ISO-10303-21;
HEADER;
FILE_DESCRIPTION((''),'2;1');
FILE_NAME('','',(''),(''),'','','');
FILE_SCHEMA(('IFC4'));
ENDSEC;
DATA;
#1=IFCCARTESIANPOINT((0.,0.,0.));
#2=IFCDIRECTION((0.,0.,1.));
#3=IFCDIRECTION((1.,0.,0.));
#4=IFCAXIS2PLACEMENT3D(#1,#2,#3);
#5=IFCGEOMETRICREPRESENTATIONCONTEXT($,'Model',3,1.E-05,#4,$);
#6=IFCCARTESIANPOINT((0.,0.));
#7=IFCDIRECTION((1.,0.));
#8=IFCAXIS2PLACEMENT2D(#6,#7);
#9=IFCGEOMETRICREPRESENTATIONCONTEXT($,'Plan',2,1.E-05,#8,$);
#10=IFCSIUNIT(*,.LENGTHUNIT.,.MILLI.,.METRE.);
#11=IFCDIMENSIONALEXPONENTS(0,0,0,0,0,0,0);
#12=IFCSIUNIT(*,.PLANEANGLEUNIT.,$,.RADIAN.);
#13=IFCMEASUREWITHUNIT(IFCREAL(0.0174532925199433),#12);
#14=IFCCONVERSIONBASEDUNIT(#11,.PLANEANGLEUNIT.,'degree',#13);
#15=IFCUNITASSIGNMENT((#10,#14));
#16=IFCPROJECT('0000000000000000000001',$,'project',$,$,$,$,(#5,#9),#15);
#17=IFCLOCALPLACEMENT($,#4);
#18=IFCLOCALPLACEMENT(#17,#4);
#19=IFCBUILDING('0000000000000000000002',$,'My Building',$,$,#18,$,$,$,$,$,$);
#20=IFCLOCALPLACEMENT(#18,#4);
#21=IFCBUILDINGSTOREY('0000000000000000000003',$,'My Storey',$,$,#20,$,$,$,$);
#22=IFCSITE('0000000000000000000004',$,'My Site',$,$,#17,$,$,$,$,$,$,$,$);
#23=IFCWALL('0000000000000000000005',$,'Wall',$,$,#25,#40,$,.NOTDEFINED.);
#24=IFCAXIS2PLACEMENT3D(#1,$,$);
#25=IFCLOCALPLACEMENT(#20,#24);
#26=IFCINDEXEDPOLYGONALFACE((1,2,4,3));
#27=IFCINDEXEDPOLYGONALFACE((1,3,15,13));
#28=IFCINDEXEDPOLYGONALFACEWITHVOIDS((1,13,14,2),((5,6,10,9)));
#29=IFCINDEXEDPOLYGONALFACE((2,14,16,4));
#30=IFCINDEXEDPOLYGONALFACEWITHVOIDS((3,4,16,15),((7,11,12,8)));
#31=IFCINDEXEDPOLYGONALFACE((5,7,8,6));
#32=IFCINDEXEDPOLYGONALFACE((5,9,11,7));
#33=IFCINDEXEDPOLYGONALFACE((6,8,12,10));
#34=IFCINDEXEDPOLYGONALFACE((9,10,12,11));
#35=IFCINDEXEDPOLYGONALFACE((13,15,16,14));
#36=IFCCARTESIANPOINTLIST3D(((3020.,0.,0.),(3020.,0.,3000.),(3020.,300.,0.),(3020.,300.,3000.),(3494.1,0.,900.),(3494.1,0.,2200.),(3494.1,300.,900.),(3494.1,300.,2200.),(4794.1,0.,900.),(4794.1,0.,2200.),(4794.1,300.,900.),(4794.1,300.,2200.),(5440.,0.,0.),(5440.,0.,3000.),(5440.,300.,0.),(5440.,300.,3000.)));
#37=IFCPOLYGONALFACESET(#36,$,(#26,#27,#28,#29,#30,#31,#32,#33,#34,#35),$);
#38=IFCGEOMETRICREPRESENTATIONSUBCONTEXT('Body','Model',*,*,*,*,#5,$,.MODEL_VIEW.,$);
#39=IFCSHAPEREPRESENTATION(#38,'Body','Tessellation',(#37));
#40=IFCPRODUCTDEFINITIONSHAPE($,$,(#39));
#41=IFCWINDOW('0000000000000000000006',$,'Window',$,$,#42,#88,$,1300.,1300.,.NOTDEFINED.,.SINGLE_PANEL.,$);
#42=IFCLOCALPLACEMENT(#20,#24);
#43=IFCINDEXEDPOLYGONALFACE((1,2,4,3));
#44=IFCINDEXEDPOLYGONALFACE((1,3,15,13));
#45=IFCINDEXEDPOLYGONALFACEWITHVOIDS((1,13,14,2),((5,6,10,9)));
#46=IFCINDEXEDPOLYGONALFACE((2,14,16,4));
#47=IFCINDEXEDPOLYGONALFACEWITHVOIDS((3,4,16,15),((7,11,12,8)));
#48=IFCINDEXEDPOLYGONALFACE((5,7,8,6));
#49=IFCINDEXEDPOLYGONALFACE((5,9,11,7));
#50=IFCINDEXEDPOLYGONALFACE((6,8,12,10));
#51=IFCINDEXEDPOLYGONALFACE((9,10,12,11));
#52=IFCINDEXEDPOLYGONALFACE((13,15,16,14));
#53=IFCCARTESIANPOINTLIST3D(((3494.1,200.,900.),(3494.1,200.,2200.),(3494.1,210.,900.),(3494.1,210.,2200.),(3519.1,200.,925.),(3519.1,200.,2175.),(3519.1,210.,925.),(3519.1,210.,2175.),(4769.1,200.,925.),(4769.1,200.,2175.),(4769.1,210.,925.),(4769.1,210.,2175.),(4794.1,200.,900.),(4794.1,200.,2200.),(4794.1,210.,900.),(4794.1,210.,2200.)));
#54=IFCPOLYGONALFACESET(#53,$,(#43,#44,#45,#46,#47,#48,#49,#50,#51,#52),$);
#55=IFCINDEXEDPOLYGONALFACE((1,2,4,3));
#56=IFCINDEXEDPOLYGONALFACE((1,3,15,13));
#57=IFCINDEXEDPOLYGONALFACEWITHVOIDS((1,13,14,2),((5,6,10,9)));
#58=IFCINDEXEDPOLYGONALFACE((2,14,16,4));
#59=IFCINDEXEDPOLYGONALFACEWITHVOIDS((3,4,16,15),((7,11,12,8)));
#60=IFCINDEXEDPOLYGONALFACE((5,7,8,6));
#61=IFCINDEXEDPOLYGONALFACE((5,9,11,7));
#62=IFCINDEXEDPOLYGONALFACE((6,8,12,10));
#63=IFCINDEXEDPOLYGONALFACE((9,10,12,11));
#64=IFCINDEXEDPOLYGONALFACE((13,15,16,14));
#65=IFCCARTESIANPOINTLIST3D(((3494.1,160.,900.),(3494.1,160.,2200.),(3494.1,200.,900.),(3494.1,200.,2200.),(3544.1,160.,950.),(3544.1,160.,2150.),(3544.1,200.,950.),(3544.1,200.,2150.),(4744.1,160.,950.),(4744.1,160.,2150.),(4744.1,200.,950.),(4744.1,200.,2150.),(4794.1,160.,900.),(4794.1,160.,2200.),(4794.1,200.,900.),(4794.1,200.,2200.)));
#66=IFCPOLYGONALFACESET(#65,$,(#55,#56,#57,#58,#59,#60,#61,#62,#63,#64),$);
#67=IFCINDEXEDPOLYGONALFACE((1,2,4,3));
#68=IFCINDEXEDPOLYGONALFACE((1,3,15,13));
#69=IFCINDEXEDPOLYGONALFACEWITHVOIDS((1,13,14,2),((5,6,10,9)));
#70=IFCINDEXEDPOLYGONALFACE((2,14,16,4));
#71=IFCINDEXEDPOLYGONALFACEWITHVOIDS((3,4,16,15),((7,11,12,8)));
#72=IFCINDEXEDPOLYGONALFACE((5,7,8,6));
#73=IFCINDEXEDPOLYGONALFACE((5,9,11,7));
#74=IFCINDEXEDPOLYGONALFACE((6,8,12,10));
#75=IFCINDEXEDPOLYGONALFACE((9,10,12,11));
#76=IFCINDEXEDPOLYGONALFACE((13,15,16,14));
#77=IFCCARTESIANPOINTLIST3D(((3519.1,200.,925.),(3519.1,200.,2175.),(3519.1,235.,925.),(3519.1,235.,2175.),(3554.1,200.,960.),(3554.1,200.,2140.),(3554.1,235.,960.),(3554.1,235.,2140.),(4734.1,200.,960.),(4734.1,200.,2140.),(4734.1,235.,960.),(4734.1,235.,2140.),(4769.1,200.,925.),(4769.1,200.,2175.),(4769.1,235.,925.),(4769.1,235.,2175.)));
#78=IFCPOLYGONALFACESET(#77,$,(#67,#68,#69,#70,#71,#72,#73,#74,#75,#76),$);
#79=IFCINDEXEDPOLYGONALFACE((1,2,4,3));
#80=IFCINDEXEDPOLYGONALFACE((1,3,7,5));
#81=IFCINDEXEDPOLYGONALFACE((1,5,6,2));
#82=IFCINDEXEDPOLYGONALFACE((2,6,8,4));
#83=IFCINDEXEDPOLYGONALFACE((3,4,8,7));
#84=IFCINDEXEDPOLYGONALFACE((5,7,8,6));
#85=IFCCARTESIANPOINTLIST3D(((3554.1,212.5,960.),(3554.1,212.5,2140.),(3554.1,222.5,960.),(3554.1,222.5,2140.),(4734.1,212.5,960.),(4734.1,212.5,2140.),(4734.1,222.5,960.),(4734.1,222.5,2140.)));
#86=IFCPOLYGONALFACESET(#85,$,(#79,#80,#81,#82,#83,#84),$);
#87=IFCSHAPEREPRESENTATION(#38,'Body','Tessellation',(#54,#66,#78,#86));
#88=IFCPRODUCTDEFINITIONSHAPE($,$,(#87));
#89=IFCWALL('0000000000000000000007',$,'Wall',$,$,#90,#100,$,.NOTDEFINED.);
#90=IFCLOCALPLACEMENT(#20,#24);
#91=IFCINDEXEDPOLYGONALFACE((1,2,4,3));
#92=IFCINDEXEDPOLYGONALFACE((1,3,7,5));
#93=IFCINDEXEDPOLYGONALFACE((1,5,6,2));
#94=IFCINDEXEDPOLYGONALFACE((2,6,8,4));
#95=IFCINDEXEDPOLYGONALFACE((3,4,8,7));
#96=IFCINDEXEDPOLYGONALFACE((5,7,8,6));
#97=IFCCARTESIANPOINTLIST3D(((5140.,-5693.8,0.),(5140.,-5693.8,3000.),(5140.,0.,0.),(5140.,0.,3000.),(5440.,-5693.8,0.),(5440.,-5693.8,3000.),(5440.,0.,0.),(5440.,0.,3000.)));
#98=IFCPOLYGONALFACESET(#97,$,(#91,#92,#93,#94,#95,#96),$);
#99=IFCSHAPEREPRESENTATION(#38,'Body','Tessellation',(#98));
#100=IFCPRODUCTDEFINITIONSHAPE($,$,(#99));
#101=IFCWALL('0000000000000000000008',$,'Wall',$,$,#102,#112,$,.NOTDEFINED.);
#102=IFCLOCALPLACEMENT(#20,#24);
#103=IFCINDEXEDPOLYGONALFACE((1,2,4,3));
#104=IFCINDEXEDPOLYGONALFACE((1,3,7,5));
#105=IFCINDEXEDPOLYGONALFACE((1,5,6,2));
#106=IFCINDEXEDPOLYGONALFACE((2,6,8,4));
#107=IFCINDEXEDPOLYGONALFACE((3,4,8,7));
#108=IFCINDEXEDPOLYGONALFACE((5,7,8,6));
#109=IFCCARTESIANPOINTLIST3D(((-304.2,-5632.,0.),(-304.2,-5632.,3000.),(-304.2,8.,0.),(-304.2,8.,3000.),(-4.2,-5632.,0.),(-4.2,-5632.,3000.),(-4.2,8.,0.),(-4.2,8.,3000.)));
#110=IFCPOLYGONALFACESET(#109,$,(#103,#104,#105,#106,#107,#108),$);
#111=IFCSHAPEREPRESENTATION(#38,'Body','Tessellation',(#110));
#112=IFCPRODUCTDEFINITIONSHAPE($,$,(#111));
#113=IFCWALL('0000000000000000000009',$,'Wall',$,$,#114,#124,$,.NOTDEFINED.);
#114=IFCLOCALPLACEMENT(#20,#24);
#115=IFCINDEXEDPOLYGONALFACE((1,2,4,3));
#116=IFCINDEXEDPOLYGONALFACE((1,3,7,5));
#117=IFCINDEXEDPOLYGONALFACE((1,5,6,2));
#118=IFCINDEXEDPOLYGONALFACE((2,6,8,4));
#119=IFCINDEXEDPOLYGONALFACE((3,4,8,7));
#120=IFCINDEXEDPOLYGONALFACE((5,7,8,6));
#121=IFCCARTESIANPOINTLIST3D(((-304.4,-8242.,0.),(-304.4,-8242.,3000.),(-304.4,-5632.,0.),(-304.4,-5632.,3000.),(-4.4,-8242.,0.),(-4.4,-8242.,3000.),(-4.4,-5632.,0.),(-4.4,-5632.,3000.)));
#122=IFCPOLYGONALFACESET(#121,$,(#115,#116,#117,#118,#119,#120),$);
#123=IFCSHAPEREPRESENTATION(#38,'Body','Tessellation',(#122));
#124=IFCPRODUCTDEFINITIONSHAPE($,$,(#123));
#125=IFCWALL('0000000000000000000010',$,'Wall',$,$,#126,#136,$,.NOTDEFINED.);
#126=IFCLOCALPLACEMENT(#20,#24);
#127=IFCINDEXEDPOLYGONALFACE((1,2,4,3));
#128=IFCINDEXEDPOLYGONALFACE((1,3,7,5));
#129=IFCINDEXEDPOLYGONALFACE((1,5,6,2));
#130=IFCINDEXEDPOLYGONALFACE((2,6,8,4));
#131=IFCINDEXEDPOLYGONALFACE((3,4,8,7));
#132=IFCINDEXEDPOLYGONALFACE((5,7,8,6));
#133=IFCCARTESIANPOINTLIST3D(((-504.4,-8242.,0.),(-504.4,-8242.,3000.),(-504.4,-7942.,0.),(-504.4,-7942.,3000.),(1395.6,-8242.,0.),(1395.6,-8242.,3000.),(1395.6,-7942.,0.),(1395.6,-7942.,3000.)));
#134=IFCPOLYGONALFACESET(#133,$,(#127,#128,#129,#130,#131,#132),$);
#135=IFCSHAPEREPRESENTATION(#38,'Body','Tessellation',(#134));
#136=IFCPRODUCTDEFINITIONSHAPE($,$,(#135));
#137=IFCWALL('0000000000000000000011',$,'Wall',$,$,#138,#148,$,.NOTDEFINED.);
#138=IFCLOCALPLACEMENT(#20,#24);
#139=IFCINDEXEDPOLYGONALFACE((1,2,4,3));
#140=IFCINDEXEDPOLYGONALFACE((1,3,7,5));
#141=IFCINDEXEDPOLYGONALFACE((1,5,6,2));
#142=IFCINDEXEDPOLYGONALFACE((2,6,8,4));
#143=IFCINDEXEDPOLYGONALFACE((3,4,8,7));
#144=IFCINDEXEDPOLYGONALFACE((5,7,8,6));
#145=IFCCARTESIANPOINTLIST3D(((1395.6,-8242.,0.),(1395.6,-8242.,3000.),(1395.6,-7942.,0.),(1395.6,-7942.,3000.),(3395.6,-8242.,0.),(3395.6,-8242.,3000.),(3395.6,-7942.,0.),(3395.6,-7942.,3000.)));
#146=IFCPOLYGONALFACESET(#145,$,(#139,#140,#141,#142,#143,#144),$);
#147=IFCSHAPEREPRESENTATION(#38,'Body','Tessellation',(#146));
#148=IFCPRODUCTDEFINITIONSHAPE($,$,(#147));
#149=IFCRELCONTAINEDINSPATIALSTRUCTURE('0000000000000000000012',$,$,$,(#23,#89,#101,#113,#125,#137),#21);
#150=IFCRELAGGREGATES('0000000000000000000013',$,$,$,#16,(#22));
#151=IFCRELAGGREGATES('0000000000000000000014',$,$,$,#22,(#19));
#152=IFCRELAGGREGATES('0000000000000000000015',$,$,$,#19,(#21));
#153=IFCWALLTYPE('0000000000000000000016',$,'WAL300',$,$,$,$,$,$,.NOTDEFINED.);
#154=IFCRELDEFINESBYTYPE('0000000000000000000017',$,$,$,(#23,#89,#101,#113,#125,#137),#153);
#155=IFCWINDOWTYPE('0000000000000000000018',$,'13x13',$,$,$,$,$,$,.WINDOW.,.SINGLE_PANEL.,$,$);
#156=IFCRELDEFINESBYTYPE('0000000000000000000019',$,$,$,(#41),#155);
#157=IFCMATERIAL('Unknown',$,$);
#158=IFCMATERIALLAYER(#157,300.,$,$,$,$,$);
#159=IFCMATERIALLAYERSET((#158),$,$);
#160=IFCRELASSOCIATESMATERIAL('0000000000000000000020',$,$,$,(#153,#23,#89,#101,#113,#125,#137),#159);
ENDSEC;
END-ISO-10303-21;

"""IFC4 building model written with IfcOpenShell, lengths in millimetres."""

from ifc_helpers import new_model, entity, si_unit, converted_unit, frame, origin_with_axes, origin_2d_with_axis, place, context, subcontext, project, spatial, line, indexed_curve, outline, extrude, shape, source, transform, mapped, material, layer, layer_set, layer_usage, type_object, type_shapes, element, fill, save


model = new_model("IFC4")

# Units and contexts
model_context = context("Model", 3, precision=1e-05, world=origin_with_axes())
plan_context = context("Plan", 2, precision=1e-05, world=origin_2d_with_axis())
body_context_1 = subcontext(model_context, "Body", "Model", "MODEL_VIEW")
body_context_2 = subcontext(plan_context, "Body", "Plan", "PLAN_VIEW")
ifc_project = project(units=[si_unit("LENGTHUNIT", "METRE", prefix="MILLI"), converted_unit("PLANEANGLEUNIT", "degree", entity("IfcReal", 0.0174532925199433), si_unit("PLANEANGLEUNIT", "RADIAN"), dimensions=[0, 0, 0, 0, 0, 0, 0])], contexts=[model_context, plan_context])

# Site, building, storey
site_placement = place(None, origin_with_axes())
site = spatial("IfcSite", under=ifc_project, at=site_placement, Name="My Site")
building_placement = place(site_placement, origin_with_axes())
building = spatial("IfcBuilding", under=site, at=building_placement, Name="My Building")
storey_placement = place(building_placement, origin_with_axes())
storey = spatial("IfcBuildingStorey", under=building, at=storey_placement, Name="My Storey")

# Shared definitions
ifc_material = material(Name="Unknown")

# Shared definitions
ifc_layer_1 = layer(ifc_material, 300.0)
ifc_layer_set_1 = layer_set([ifc_layer_1])
wall_type_1 = type_object("IfcWallType", Name="WAL300", PredefinedType="NOTDEFINED", material=ifc_layer_set_1)

# Wall, opening, window
ifc_layer_usage_1 = layer_usage(ifc_layer_set_1, "AXIS2", "POSITIVE", 0.0)
wall_1_placement = place(storey_placement, frame((3020.0, 0.0, 0.0), z_axis=(0.0, 0.0, 1.0), x_axis=(1.0, 0.0, 0.0)))
wall_1 = element("IfcWall", 1, at=wall_1_placement, inside=storey, type_object=wall_type_1, material=ifc_layer_usage_1, Name="Wall", PredefinedType="NOTDEFINED", context=body_context_1, shape_type="SweptSolid", body=[
    extrude(outline(indexed_curve([(0.0, 0.0), (0.0, 300.0), (2420.0, 300.0), (2420.0, 0.0), (0.0, 0.0)], self_intersect=False)), origin_with_axes(), (0.0, 0.0, 1.0), 3000.0),
])
shared_shape_1 = source(origin_with_axes(), body_context_1, "Body", "SweptSolid", [
    extrude(outline(indexed_curve([(0.0, 0.0, 0.0), (1300.0, 0.0, 0.0), (1300.0, 0.0, 1300.0), (0.0, 0.0, 1300.0)], segments=[line(1, 2), line(2, 3), line(3, 4), line(4, 1)])), frame((0.0, -100.0, 0.0), z_axis=(0.0, 0.0, 1.0), x_axis=(1.0, 0.0, 0.0)), (0.0, 1.0, 0.0), 500.0),
])
opening_1_placement = place(wall_1_placement, frame((474.1, 0.0, 900.0), z_axis=(0.0, 0.0, 1.0), x_axis=(1.0, 0.0, 0.0)))
opening_1 = element("IfcOpeningElement", 2, at=opening_1_placement, cuts=wall_1, PredefinedType="OPENING", context=body_context_1, shape_type="MappedRepresentation", body=[
    mapped(shared_shape_1, transform((0.0, 0.0, 0.0), x_axis=(1.0, 0.0, 0.0), y_axis=(0.0, 1.0, 0.0), z_axis=(0.0, 0.0, 1.0), scale=1.0)),
])
window_type_1 = type_object("IfcWindowType", Name="13x13", PartitioningType="SINGLE_PANEL", PredefinedType="WINDOW")
shared_shape_2 = source(origin_with_axes(), body_context_1, "Body", "SweptSolid", [
    extrude(outline(indexed_curve([(0.0, 0.0, 0.0), (1300.0, 0.0, 0.0), (1300.0, 0.0, 1300.0), (0.0, 0.0, 1300.0)], segments=[line(1, 2), line(2, 3), line(3, 4), line(4, 1)]), holes=[indexed_curve([(25.0, 0.0, 25.0), (1275.0, 0.0, 25.0), (1275.0, 0.0, 1275.0), (25.0, 0.0, 1275.0)], segments=[line(1, 2), line(2, 3), line(3, 4), line(4, 1)])]), frame((0.0, 200.0, 0.0), z_axis=(0.0, 0.0, 1.0), x_axis=(1.0, 0.0, 0.0)), (0.0, 1.0, 0.0), 10.0),
    extrude(outline(indexed_curve([(0.0, 0.0, 0.0), (1300.0, 0.0, 0.0), (1300.0, 0.0, 1300.0), (0.0, 0.0, 1300.0)], segments=[line(1, 2), line(2, 3), line(3, 4), line(4, 1)]), holes=[indexed_curve([(50.0, 0.0, 50.0), (1250.0, 0.0, 50.0), (1250.0, 0.0, 1250.0), (50.0, 0.0, 1250.0)], segments=[line(1, 2), line(2, 3), line(3, 4), line(4, 1)])]), frame((0.0, 160.0, 0.0), z_axis=(0.0, 0.0, 1.0), x_axis=(1.0, 0.0, 0.0)), (0.0, 1.0, 0.0), 40.0),
    extrude(outline(indexed_curve([(0.0, 0.0, 0.0), (1250.0, 0.0, 0.0), (1250.0, 0.0, 1250.0), (0.0, 0.0, 1250.0)], segments=[line(1, 2), line(2, 3), line(3, 4), line(4, 1)]), holes=[indexed_curve([(35.0, 0.0, 35.0), (1215.0, 0.0, 35.0), (1215.0, 0.0, 1215.0), (35.0, 0.0, 1215.0)], segments=[line(1, 2), line(2, 3), line(3, 4), line(4, 1)])]), frame((25.0, 200.0, 25.0), z_axis=(0.0, 0.0, 1.0), x_axis=(1.0, 0.0, 0.0)), (0.0, 1.0, 0.0), 35.0),
    extrude(outline(indexed_curve([(35.0, 0.0, 35.0), (1215.0, 0.0, 35.0), (1215.0, 0.0, 1215.0), (35.0, 0.0, 1215.0)], segments=[line(1, 2), line(2, 3), line(3, 4), line(4, 1)])), frame((25.0, 212.5, 25.0), z_axis=(0.0, 0.0, 1.0), x_axis=(1.0, 0.0, 0.0)), (0.0, 1.0, 0.0), 10.0),
])
shared_shape_3 = source(origin_with_axes(), body_context_2, "Body", "Curve2D", [
    entity("IfcIndexedPolyCurve", entity("IfcCartesianPointList2D", [[50.0, 160.0], [1250.0, 160.0]]), [entity("IfcLineIndex", [1, 2])]),
    entity("IfcIndexedPolyCurve", entity("IfcCartesianPointList2D", [[0.0, 210.0], [25.0, 210.0], [25.0, 200.0], [50.0, 200.0], [50.0, 160.0], [0.0, 160.0]]), [entity("IfcLineIndex", [1, 2]), entity("IfcLineIndex", [2, 3]), entity("IfcLineIndex", [3, 4]), entity("IfcLineIndex", [4, 5]), entity("IfcLineIndex", [5, 6]), entity("IfcLineIndex", [6, 1])]),
    entity("IfcIndexedPolyCurve", entity("IfcCartesianPointList2D", [[1300.0, 210.0], [1275.0, 210.0], [1275.0, 200.0], [1250.0, 200.0], [1250.0, 160.0], [1300.0, 160.0]]), [entity("IfcLineIndex", [1, 2]), entity("IfcLineIndex", [2, 3]), entity("IfcLineIndex", [3, 4]), entity("IfcLineIndex", [4, 5]), entity("IfcLineIndex", [5, 6]), entity("IfcLineIndex", [6, 1])]),
    entity("IfcIndexedPolyCurve", entity("IfcCartesianPointList2D", [[25.0, 200.0], [60.0, 200.0], [60.0, 235.0], [25.0, 235.0]]), [entity("IfcLineIndex", [1, 2]), entity("IfcLineIndex", [2, 3]), entity("IfcLineIndex", [3, 4]), entity("IfcLineIndex", [4, 1])]),
    entity("IfcIndexedPolyCurve", entity("IfcCartesianPointList2D", [[1275.0, 200.0], [1240.0, 200.0], [1240.0, 235.0], [1275.0, 235.0]]), [entity("IfcLineIndex", [1, 2]), entity("IfcLineIndex", [2, 3]), entity("IfcLineIndex", [3, 4]), entity("IfcLineIndex", [4, 1])]),
    entity("IfcIndexedPolyCurve", entity("IfcCartesianPointList2D", [[60.0, 200.0], [1240.0, 200.0]]), [entity("IfcLineIndex", [1, 2])]),
    entity("IfcIndexedPolyCurve", entity("IfcCartesianPointList2D", [[60.0, 235.0], [1240.0, 235.0]]), [entity("IfcLineIndex", [1, 2])]),
    entity("IfcIndexedPolyCurve", entity("IfcCartesianPointList2D", [[60.0, 217.5], [1240.0, 217.5]]), [entity("IfcLineIndex", [1, 2])]),
])
type_shapes(window_type_1, [shared_shape_2, shared_shape_3])
window_1_placement = place(opening_1_placement, origin_with_axes())
window_1 = element("IfcWindow", 3, at=window_1_placement, type_object=window_type_1, Name="Window", OverallHeight=1300.0, OverallWidth=1300.0, PartitioningType="SINGLE_PANEL", PredefinedType="NOTDEFINED", shapes=[
    shape(body_context_1, "Body", "MappedRepresentation", [mapped(shared_shape_2, transform((0.0, 0.0, 0.0), x_axis=(1.0, 0.0, 0.0), y_axis=(0.0, 1.0, 0.0), z_axis=(0.0, 0.0, 1.0), scale=1.0))]),
    shape(body_context_2, "Body", "MappedRepresentation", [mapped(shared_shape_3, transform((0.0, 0.0, 0.0), x_axis=(1.0, 0.0, 0.0), y_axis=(0.0, 1.0, 0.0), z_axis=(0.0, 0.0, 1.0), scale=1.0))]),
])
fill(opening_1, window_1)

# Walls
ifc_layer_usage_2 = layer_usage(ifc_layer_set_1, "AXIS2", "POSITIVE", 0.0)
wall_2_placement = place(storey_placement, frame((5140.0, 0.0, 0.0), z_axis=(0.0, 0.0, 1.0), x_axis=(0.0, -1.0, 0.0)))
element("IfcWall", 4, at=wall_2_placement, inside=storey, type_object=wall_type_1, material=ifc_layer_usage_2, Name="Wall", PredefinedType="NOTDEFINED", context=body_context_1, shape_type="SweptSolid", body=[
    extrude(outline(indexed_curve([(0.0, 0.0), (0.0, 300.0), (5693.8, 300.0), (5693.8, 0.0), (0.0, 0.0)], self_intersect=False)), origin_with_axes(), (0.0, 0.0, 1.0), 3000.0),
])
ifc_layer_usage_3 = layer_usage(ifc_layer_set_1, "AXIS2", "POSITIVE", 0.0)
wall_3_placement = place(storey_placement, frame((-4.2, -5632.0, 0.0), z_axis=(0.0, 0.0, 1.0), x_axis=(0.0, 1.0, 0.0)))
element("IfcWall", 5, at=wall_3_placement, inside=storey, type_object=wall_type_1, material=ifc_layer_usage_3, Name="Wall", PredefinedType="NOTDEFINED", context=body_context_1, shape_type="SweptSolid", body=[
    extrude(outline(indexed_curve([(0.0, 0.0), (0.0, 300.0), (5640.0, 300.0), (5640.0, 0.0), (0.0, 0.0)], self_intersect=False)), origin_with_axes(), (0.0, 0.0, 1.0), 3000.0),
])
ifc_layer_usage_4 = layer_usage(ifc_layer_set_1, "AXIS2", "POSITIVE", 0.0)
wall_4_placement = place(storey_placement, frame((-4.4, -8242.0, 0.0), z_axis=(0.0, 0.0, 1.0), x_axis=(0.000001, 1.0, 0.0)))
element("IfcWall", 6, at=wall_4_placement, inside=storey, type_object=wall_type_1, material=ifc_layer_usage_4, Name="Wall", PredefinedType="NOTDEFINED", context=body_context_1, shape_type="SweptSolid", body=[
    extrude(outline(indexed_curve([(0.0, 0.0), (0.0, 300.0), (2610.0, 300.0), (2610.0, 0.0), (0.0, 0.0)], self_intersect=False)), origin_with_axes(), (0.0, 0.0, 1.0), 3000.0),
])
ifc_layer_usage_5 = layer_usage(ifc_layer_set_1, "AXIS2", "POSITIVE", 0.0)
wall_5_placement = place(storey_placement, frame((1395.6, -7942.0, 0.0), z_axis=(0.0, 0.0, 1.0), x_axis=(-1.0, 0.000001, 0.0)))
element("IfcWall", 7, at=wall_5_placement, inside=storey, type_object=wall_type_1, material=ifc_layer_usage_5, Name="Wall", PredefinedType="NOTDEFINED", context=body_context_1, shape_type="SweptSolid", body=[
    extrude(outline(indexed_curve([(0.0, 0.0), (0.0, 300.0), (1900.0, 300.0), (1900.0, 0.0), (0.0, 0.0)], self_intersect=False)), origin_with_axes(), (0.0, 0.0, 1.0), 3000.0),
])
ifc_layer_usage_6 = layer_usage(ifc_layer_set_1, "AXIS2", "POSITIVE", 0.0)
wall_6_placement = place(storey_placement, frame((1395.6, -8242.0, 0.0), z_axis=(0.0, 0.0, 1.0), x_axis=(1.0, -0.000001, 0.0)))
element("IfcWall", 8, at=wall_6_placement, inside=storey, type_object=wall_type_1, material=ifc_layer_usage_6, Name="Wall", PredefinedType="NOTDEFINED", context=body_context_1, shape_type="SweptSolid", body=[
    extrude(outline(indexed_curve([(0.0, 0.0), (0.0, 300.0), (2000.0, 300.0), (2000.0, 0.0), (0.0, 0.0)], self_intersect=False)), origin_with_axes(), (0.0, 0.0, 1.0), 3000.0),
])

save(model, "model.ifc")
